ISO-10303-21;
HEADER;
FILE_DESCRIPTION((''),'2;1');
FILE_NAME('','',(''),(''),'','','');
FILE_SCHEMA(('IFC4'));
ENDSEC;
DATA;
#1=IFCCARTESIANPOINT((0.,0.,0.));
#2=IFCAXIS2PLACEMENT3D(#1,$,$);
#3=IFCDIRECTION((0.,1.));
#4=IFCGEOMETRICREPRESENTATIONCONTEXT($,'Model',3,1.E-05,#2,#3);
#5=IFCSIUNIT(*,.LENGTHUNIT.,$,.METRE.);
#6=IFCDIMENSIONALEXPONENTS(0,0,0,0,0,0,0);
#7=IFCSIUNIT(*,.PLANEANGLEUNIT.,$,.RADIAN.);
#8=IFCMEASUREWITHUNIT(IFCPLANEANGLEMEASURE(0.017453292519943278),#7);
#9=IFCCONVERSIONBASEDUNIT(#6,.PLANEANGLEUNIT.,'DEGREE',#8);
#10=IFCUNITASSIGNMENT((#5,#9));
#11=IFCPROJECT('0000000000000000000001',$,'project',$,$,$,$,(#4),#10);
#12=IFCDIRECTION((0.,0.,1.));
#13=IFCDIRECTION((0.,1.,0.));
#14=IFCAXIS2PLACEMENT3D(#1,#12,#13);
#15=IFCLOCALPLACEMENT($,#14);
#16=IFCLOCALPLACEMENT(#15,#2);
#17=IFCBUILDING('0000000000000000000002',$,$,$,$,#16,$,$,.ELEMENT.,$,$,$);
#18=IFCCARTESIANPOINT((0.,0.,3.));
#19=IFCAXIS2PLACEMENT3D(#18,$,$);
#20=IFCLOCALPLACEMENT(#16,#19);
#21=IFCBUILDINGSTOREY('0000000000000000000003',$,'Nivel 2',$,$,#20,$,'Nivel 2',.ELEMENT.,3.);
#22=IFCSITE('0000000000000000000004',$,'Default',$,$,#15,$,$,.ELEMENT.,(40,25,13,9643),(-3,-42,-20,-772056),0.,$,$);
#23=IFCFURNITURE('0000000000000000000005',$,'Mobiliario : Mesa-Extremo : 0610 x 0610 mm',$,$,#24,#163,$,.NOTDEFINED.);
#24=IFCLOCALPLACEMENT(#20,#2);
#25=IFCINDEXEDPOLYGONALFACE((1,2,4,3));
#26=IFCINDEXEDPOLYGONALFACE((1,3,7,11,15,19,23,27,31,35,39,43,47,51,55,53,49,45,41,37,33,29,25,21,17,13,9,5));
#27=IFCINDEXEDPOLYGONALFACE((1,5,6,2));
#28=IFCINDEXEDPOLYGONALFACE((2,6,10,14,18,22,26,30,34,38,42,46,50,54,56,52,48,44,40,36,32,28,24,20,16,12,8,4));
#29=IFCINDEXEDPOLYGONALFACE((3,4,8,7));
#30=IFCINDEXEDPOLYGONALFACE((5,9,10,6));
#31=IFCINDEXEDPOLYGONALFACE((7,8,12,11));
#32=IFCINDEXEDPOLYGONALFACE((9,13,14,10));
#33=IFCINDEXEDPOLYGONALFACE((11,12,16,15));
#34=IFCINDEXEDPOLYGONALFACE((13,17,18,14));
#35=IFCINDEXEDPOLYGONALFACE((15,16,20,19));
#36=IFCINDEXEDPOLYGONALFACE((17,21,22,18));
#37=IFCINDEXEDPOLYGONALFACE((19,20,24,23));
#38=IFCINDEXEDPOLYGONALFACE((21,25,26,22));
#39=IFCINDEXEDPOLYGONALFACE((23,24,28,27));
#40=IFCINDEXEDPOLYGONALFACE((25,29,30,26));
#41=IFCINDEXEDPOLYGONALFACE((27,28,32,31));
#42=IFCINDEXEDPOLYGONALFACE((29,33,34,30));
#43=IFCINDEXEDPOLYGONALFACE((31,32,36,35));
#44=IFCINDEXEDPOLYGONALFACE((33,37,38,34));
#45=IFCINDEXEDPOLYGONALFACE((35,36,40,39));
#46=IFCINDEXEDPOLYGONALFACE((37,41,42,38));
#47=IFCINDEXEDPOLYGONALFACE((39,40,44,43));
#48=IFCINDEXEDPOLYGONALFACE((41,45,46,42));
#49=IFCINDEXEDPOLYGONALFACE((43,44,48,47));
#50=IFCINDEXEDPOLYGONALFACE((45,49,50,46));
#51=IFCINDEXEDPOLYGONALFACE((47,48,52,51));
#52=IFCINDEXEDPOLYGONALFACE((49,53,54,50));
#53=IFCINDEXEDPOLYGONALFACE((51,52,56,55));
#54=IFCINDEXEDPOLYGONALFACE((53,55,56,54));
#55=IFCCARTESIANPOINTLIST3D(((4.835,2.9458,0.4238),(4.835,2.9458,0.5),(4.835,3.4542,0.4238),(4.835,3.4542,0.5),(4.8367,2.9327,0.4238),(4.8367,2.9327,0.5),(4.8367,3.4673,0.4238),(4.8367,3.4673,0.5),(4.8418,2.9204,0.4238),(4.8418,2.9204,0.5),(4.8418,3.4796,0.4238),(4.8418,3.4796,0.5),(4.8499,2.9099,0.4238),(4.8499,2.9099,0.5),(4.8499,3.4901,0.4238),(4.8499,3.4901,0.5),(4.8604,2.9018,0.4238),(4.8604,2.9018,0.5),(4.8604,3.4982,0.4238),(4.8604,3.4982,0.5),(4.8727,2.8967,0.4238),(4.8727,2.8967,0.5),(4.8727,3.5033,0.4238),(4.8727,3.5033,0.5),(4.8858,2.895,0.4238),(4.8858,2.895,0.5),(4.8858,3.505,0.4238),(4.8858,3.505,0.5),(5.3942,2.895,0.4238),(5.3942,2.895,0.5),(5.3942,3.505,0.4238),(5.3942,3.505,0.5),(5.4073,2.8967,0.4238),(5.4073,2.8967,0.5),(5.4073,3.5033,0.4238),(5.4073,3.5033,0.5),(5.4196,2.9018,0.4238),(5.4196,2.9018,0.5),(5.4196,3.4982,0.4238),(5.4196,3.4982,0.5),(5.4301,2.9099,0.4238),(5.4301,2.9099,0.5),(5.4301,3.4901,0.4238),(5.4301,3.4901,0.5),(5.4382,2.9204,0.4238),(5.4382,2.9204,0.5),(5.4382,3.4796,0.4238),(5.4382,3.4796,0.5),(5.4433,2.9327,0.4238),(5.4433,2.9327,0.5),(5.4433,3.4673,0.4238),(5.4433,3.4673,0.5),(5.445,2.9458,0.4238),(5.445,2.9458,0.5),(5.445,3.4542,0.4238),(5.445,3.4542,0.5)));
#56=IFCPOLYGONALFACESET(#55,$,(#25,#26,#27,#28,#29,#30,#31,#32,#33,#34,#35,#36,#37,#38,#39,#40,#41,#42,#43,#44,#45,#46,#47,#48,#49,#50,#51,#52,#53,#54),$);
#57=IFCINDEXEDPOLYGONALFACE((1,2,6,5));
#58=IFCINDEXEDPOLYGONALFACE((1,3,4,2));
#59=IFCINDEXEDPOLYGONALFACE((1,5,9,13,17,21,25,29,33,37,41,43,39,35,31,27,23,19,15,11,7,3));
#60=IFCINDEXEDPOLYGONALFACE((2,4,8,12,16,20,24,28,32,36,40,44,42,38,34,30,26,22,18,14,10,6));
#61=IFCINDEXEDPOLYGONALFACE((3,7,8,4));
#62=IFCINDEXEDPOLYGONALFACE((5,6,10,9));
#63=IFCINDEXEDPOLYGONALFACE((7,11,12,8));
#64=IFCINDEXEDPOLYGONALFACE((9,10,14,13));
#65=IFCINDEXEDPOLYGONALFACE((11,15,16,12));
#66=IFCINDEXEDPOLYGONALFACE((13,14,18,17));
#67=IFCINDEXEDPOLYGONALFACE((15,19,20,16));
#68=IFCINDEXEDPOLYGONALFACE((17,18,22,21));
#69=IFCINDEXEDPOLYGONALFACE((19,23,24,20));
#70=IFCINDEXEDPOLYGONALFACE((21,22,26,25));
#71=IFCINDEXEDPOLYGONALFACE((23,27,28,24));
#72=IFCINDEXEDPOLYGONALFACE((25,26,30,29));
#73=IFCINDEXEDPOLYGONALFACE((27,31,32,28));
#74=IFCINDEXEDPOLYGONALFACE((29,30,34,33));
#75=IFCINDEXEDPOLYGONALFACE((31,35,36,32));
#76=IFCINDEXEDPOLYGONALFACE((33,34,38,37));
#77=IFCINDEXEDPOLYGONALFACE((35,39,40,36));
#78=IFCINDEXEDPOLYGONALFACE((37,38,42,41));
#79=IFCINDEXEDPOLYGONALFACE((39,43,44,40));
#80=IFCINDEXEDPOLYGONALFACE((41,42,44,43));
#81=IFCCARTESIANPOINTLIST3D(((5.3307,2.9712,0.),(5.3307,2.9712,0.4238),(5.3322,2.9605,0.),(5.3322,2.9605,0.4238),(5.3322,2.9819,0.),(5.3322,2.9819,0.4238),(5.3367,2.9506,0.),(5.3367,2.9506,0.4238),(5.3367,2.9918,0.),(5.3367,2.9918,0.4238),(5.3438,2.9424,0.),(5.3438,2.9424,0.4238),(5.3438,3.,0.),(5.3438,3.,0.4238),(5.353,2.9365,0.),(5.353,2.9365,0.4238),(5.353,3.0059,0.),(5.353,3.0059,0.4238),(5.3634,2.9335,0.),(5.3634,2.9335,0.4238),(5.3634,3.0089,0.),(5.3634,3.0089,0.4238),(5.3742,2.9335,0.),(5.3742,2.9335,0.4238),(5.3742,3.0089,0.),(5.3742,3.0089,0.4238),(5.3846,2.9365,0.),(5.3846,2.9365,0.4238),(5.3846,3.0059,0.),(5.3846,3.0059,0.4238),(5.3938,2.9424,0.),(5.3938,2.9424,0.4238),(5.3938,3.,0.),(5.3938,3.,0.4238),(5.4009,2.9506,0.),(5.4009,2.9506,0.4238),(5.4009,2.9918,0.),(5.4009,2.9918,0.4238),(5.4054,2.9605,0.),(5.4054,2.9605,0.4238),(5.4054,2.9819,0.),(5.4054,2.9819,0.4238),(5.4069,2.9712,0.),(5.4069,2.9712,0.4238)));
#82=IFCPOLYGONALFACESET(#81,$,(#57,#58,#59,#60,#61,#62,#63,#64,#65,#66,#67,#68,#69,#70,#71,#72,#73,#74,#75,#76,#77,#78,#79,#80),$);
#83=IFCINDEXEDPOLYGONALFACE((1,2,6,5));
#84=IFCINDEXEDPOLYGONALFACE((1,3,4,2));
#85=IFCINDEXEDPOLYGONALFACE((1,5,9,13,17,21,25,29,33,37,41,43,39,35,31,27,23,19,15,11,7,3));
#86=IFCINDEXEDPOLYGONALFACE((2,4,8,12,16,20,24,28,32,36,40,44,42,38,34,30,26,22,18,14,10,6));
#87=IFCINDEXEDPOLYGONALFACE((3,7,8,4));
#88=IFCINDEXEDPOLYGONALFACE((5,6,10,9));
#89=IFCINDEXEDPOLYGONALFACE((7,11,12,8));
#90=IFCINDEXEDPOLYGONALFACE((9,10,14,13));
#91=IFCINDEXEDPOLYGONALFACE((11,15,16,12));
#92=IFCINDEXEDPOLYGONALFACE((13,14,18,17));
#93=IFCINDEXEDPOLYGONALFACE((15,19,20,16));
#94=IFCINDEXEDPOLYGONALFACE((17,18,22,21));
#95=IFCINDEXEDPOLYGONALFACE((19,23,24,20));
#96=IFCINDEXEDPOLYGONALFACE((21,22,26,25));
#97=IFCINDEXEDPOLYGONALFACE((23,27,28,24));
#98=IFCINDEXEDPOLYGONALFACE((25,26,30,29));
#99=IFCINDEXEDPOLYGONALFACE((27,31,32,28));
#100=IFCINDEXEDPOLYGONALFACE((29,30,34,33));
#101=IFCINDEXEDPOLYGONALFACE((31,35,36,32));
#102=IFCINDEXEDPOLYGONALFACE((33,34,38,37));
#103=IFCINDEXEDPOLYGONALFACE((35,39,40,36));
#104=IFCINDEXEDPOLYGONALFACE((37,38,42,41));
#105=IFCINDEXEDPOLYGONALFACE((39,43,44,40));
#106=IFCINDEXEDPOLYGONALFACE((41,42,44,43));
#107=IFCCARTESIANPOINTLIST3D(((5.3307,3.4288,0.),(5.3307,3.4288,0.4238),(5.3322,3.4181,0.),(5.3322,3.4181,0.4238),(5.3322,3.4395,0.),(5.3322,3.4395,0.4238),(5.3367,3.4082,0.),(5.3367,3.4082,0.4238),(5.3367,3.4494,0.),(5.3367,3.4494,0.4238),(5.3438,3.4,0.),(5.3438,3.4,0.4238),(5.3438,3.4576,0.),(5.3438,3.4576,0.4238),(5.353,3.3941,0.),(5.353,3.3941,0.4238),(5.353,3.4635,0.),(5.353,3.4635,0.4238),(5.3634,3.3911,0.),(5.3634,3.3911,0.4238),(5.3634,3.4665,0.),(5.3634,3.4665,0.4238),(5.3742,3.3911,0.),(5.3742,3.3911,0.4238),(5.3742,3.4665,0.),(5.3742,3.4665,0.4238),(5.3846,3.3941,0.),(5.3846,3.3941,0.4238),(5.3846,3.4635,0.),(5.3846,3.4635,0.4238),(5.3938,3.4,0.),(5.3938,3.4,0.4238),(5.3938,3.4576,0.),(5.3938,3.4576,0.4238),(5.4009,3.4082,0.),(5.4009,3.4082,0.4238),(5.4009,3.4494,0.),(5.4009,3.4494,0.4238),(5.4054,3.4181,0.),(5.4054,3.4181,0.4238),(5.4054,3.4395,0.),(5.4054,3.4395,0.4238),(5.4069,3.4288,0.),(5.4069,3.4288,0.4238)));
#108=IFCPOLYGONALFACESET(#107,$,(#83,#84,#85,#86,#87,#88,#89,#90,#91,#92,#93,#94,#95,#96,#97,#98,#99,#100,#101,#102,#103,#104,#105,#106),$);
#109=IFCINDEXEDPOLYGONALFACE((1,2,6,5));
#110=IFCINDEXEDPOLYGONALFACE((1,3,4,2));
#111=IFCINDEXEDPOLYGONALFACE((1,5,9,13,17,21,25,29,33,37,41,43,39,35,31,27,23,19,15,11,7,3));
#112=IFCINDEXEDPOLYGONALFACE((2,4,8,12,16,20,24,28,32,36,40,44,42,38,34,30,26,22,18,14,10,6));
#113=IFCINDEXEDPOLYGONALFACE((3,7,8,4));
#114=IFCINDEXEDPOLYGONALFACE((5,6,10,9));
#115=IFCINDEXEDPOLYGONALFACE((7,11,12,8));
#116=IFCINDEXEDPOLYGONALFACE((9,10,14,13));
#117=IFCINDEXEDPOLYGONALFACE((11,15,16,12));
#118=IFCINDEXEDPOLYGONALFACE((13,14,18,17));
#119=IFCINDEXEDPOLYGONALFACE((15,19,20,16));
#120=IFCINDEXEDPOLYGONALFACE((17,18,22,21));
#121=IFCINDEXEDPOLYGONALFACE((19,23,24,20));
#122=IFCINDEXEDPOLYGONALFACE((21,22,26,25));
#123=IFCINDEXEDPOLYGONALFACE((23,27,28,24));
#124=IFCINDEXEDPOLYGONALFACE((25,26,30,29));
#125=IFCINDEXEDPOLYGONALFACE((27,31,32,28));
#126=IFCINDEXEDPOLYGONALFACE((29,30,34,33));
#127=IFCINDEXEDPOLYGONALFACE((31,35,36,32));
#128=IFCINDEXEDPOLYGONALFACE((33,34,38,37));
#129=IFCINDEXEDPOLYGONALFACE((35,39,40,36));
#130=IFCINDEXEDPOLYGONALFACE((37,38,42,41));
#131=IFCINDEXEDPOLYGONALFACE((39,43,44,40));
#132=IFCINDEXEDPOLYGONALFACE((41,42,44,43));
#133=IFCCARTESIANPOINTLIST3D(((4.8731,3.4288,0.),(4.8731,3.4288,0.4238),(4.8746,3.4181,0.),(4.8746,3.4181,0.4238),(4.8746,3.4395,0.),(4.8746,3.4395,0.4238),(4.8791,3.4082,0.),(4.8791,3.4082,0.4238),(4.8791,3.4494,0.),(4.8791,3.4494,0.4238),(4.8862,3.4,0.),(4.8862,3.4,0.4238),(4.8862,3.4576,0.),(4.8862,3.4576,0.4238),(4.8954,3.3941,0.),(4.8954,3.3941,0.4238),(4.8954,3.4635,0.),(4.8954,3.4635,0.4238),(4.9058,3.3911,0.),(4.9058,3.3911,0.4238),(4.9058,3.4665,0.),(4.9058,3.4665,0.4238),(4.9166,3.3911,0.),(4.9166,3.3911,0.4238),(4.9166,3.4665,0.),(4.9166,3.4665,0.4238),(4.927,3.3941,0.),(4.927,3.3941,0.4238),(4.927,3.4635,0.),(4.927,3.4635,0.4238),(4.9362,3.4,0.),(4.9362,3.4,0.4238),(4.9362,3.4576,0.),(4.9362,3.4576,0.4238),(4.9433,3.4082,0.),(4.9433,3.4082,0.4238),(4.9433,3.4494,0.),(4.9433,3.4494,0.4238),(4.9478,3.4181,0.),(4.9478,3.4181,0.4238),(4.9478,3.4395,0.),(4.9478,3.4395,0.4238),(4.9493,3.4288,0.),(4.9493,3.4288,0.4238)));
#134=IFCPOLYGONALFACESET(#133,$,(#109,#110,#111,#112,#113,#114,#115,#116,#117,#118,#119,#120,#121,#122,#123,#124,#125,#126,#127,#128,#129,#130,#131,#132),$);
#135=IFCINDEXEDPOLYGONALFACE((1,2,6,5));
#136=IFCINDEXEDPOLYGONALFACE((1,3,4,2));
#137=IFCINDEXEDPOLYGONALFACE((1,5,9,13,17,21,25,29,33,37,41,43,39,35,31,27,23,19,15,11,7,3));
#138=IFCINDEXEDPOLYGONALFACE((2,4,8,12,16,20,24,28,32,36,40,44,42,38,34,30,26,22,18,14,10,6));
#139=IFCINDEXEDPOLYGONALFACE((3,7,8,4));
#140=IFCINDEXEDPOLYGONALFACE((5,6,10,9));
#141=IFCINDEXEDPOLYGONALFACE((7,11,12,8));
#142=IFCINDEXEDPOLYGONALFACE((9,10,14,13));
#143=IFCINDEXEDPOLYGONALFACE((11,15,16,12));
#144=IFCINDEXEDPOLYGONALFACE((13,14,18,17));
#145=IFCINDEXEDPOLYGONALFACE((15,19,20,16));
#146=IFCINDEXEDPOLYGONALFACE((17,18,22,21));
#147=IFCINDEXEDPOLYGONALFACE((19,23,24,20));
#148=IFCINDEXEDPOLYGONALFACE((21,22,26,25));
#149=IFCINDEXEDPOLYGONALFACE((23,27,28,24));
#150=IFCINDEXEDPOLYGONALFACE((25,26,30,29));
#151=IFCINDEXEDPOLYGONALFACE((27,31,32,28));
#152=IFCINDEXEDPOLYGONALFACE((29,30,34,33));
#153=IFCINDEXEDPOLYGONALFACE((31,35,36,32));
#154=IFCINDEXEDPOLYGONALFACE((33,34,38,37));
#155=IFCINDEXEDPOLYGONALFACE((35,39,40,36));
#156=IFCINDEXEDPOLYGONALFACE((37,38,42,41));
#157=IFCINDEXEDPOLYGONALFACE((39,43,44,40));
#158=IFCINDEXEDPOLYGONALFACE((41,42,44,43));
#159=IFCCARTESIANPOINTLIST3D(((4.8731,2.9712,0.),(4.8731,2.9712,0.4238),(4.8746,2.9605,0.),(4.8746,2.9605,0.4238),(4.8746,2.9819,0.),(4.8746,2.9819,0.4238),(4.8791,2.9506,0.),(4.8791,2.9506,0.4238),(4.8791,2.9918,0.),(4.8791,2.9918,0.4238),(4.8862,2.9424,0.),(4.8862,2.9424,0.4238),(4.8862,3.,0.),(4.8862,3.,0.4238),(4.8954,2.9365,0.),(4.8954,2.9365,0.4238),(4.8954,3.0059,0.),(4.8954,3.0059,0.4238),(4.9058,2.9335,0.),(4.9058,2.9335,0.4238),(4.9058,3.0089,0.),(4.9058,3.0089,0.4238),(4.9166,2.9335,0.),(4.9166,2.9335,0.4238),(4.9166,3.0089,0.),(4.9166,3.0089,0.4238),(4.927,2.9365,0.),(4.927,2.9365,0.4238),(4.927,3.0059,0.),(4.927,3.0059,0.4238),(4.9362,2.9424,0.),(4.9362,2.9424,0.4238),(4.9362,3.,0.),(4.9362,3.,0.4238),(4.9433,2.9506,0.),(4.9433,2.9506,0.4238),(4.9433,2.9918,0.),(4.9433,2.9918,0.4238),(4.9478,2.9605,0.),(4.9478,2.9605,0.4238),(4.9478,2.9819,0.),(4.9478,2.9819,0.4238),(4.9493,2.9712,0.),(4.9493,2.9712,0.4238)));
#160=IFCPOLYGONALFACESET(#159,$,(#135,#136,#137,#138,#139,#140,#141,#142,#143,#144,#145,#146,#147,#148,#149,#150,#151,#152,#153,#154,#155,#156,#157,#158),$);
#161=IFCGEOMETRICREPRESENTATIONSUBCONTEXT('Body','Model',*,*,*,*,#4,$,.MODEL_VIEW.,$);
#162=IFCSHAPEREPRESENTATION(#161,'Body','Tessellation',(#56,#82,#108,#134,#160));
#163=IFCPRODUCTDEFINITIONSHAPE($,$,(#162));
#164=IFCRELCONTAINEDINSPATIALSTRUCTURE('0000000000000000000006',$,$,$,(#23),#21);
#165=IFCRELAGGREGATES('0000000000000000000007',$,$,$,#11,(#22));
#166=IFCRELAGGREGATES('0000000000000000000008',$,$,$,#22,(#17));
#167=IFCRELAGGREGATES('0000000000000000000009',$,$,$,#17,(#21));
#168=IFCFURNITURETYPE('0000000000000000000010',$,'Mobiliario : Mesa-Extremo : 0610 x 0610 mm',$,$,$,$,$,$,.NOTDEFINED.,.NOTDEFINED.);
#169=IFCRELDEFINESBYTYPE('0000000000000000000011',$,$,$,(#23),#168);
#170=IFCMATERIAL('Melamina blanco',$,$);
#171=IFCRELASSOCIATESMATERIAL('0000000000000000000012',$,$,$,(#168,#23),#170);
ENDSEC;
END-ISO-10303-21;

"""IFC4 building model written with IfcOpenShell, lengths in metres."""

from ifc_helpers import new_model, entity, si_unit, converted_unit, direction, frame, origin, place, context, subcontext, project, spatial, line, arc, indexed_curve, outline, extrude, source, transform, mapped, material, type_object, type_shapes, element, save


model = new_model("IFC4")

# Units and contexts
model_context = context("Model", 3, precision=1e-05, world=origin(), true_north=direction((0.0, 1.0)))
body_context = subcontext(model_context, "Body", "Model", "MODEL_VIEW")
ifc_project = project(units=[si_unit("LENGTHUNIT", "METRE"), converted_unit("PLANEANGLEUNIT", "DEGREE", entity("IfcPlaneAngleMeasure", 0.017453292519943278), si_unit("PLANEANGLEUNIT", "RADIAN"), dimensions=[0, 0, 0, 0, 0, 0, 0])], contexts=[model_context])

# Site, building, storey
site_placement = place(None, frame((0.0, 0.0, 0.0), z_axis=(0.0, 0.0, 1.0), x_axis=(0.0, 1.0, 0.0)))
site = spatial("IfcSite", under=ifc_project, at=site_placement, Name="Default", CompositionType="ELEMENT", RefLatitude=(40, 25, 13, 9643), RefLongitude=(-3, -42, -20, -772056), RefElevation=0.0)
building_placement = place(site_placement, origin())
building = spatial("IfcBuilding", under=site, at=building_placement, CompositionType="ELEMENT")
storey_placement = place(building_placement, frame((0.0, 0.0, 3.0)))
storey = spatial("IfcBuildingStorey", under=building, at=storey_placement, Name="Nivel 2", LongName="Nivel 2", CompositionType="ELEMENT", Elevation=3.0)

# Furniture
ifc_material_1 = material(Name="Melamina blanco")
furniture_type_1 = type_object("IfcFurnitureType", Name="Mobiliario : Mesa-Extremo : 0610 x 0610 mm", AssemblyPlace="NOTDEFINED", PredefinedType="NOTDEFINED", material=ifc_material_1)
shared_shape_1 = source(origin(), body_context, "Body", "SweptSolid", [
    extrude(outline(indexed_curve([(0.2542, -0.305), (0.2901, -0.2901), (0.305, -0.2542), (0.305, 0.2542), (0.2901, 0.2901), (0.2542, 0.305), (-0.2542, 0.305), (-0.2901, 0.2901), (-0.305, 0.2542), (-0.305, -0.2542), (-0.2901, -0.2901), (-0.2542, -0.305)], segments=[arc(1, 2, 3), line(3, 4), arc(4, 5, 6), line(6, 7), arc(7, 8, 9), line(9, 10), arc(10, 11, 12), line(12, 1)], self_intersect=False)), frame((0.3087, 0.1524, 0.4238)), (0.0, 0.0, 1.0), 0.0762),
    extrude(outline(indexed_curve([(-0.0381, 0.0), (0.0, -0.0381), (0.0381, 0.0), (0.0, 0.0381)], segments=[arc(1, 2, 3), arc(3, 4, 1)], self_intersect=False)), frame((0.5375, -0.0764, 0.0)), (0.0, 0.0, 1.0), 0.4238),
    extrude(outline(indexed_curve([(-0.0381, 0.0), (0.0, -0.0381), (0.0381, 0.0), (0.0, 0.0381)], segments=[arc(1, 2, 3), arc(3, 4, 1)], self_intersect=False)), frame((0.5375, 0.3812, 0.0)), (0.0, 0.0, 1.0), 0.4238),
    extrude(outline(indexed_curve([(-0.0381, 0.0), (0.0, -0.0381), (0.0381, 0.0), (0.0, 0.0381)], segments=[arc(1, 2, 3), arc(3, 4, 1)], self_intersect=False)), frame((0.0799, 0.3812, 0.0)), (0.0, 0.0, 1.0), 0.4238),
    extrude(outline(indexed_curve([(-0.0381, 0.0), (0.0, -0.0381), (0.0381, 0.0), (0.0, 0.0381)], segments=[arc(1, 2, 3), arc(3, 4, 1)], self_intersect=False)), frame((0.0799, -0.0764, 0.0)), (0.0, 0.0, 1.0), 0.4238),
])
type_shapes(furniture_type_1, [shared_shape_1])
furniture_1_placement = place(storey_placement, frame((4.8313, 3.0476, 0.0)))
element("IfcFurniture", 1, at=furniture_1_placement, inside=storey, type_object=furniture_type_1, material=ifc_material_1, Name="Mobiliario : Mesa-Extremo : 0610 x 0610 mm", PredefinedType="NOTDEFINED", context=body_context, shape_type="MappedRepresentation", body=[
    mapped(shared_shape_1, transform((0.0, 0.0, 0.0), scale=1.0)),
])

save(model, "model.ifc")
